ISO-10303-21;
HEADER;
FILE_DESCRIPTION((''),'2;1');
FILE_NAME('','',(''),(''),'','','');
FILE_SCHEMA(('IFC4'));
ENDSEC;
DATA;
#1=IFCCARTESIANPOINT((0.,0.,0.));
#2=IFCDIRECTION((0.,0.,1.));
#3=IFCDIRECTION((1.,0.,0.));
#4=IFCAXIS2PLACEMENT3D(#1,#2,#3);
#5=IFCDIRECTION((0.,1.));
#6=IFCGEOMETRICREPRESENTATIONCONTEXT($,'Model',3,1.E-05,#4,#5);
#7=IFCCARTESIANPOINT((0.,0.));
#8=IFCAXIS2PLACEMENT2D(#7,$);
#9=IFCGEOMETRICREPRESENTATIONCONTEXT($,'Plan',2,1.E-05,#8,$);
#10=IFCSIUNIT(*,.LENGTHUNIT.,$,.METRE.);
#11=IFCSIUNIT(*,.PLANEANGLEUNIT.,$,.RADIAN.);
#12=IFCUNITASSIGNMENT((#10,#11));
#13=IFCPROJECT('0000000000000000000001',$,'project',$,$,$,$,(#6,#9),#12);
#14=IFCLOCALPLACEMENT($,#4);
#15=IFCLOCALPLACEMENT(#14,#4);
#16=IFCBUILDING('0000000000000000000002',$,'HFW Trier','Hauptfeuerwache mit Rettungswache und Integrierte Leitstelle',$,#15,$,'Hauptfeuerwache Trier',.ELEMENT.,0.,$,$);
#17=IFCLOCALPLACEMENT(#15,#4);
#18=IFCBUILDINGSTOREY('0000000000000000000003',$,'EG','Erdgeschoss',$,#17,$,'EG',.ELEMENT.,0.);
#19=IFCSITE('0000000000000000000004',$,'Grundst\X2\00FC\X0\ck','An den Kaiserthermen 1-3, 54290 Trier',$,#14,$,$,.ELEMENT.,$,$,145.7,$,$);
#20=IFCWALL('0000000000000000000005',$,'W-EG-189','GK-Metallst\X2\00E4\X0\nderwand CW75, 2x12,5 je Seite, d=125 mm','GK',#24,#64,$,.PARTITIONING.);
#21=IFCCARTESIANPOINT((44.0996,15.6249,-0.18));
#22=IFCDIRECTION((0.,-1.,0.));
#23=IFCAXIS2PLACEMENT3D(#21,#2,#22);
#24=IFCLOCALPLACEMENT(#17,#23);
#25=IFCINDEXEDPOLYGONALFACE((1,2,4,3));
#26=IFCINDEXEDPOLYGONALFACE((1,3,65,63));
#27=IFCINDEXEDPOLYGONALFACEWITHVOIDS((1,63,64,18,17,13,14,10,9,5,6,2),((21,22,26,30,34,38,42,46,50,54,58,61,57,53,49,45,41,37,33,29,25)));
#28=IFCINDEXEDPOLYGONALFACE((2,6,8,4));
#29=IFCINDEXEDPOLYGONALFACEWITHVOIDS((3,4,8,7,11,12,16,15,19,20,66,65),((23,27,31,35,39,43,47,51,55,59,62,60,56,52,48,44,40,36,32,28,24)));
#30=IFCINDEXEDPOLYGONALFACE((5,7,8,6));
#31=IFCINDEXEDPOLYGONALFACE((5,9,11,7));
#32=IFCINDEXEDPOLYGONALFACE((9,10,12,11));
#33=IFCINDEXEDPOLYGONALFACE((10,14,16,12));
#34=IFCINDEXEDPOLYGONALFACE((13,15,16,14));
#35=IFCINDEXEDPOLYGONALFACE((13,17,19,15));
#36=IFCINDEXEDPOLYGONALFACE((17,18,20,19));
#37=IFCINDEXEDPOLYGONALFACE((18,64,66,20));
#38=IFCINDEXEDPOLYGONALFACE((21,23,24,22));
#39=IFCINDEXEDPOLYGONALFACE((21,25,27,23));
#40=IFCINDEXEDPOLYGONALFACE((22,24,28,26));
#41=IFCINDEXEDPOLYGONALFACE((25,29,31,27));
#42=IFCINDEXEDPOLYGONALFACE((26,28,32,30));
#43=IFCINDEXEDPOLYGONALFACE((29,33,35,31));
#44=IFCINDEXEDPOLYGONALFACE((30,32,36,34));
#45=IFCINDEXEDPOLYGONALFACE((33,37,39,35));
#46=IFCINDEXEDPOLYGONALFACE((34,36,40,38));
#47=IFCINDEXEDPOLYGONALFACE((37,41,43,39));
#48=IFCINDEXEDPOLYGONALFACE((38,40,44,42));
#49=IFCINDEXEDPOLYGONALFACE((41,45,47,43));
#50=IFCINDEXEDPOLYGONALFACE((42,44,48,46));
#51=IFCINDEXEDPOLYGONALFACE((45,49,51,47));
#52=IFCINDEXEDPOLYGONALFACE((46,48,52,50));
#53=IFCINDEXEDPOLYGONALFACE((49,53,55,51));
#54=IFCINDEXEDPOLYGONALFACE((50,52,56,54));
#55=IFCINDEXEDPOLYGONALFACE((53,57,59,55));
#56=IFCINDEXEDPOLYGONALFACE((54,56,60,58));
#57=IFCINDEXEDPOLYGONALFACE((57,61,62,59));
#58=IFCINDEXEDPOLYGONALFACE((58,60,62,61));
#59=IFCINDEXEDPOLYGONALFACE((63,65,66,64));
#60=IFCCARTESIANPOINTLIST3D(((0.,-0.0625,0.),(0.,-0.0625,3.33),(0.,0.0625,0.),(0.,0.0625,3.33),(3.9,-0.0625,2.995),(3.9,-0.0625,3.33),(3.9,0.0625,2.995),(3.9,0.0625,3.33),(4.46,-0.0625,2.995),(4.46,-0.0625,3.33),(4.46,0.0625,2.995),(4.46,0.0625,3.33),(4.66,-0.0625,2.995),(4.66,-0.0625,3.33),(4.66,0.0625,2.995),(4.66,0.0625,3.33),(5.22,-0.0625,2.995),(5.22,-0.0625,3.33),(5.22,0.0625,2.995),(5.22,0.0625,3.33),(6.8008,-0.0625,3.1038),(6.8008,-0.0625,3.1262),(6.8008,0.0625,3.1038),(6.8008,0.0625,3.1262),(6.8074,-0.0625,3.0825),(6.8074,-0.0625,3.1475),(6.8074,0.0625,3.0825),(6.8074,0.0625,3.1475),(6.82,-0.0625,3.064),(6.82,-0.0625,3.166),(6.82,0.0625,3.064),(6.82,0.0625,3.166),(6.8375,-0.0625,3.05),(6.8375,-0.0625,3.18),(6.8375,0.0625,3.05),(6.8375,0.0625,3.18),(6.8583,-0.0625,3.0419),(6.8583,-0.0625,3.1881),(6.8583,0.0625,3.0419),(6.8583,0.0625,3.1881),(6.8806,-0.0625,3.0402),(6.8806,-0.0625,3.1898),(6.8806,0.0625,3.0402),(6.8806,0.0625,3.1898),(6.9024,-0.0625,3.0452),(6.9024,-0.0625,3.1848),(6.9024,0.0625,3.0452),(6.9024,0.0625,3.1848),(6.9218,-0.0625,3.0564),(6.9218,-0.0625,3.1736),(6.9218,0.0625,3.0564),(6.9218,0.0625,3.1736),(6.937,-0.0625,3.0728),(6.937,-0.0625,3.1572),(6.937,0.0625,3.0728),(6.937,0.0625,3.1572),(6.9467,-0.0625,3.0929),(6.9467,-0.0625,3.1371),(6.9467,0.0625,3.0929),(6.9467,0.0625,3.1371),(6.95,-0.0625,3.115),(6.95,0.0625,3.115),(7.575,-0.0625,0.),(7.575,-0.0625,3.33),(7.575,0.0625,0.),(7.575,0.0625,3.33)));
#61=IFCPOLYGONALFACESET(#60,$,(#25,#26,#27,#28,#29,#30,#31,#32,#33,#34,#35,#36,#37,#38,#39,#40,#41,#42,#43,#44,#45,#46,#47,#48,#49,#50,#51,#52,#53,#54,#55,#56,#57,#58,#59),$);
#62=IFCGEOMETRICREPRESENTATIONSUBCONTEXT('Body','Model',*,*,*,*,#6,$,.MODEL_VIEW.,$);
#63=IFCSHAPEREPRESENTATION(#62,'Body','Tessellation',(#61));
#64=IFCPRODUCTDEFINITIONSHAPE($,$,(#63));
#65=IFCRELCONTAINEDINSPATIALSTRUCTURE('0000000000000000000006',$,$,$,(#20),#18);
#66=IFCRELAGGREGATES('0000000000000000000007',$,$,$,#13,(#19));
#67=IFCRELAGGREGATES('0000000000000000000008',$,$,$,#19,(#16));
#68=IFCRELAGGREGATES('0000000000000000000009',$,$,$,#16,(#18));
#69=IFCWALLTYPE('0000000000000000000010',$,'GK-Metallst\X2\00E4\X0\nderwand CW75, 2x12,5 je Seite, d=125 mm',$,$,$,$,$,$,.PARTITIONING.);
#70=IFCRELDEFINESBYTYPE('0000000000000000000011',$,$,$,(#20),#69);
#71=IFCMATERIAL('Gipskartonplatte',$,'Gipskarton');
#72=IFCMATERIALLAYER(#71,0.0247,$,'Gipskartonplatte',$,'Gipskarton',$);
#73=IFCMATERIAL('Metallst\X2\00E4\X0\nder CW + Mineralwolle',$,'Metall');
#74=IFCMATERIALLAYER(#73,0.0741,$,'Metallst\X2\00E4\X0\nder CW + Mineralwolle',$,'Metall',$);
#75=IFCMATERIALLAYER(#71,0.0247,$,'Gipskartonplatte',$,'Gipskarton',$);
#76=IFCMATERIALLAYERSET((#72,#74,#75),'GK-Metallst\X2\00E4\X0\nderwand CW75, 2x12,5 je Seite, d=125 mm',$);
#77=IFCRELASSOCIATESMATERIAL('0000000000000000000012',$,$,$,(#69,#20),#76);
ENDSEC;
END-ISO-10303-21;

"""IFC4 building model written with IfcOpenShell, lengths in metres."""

from ifc_helpers import new_model, si_unit, direction, frame, frame_2d, origin_with_axes, origin_2d, place, context, subcontext, project, spatial, rectangle, circle, extrude, material, layer, layer_set, layer_usage, type_object, element, save


model = new_model("IFC4")

# Units and contexts
model_context = context("Model", 3, precision=1e-05, world=origin_with_axes(), true_north=direction((0.0, 1.0)))
plan_context = context("Plan", 2, precision=1e-05, world=origin_2d())
body_context = subcontext(model_context, "Body", "Model", "MODEL_VIEW")
ifc_project = project(units=[si_unit("LENGTHUNIT", "METRE"), si_unit("PLANEANGLEUNIT", "RADIAN")], contexts=[model_context, plan_context])

# Site, building, storey
site_placement = place(None, origin_with_axes())
site = spatial("IfcSite", under=ifc_project, at=site_placement, Name="Grundstück", Description="An den Kaiserthermen 1-3, 54290 Trier", CompositionType="ELEMENT", RefElevation=145.7)
building_placement = place(site_placement, origin_with_axes())
building = spatial("IfcBuilding", under=site, at=building_placement, Name="HFW Trier", Description="Hauptfeuerwache mit Rettungswache und Integrierte Leitstelle", LongName="Hauptfeuerwache Trier", CompositionType="ELEMENT", ElevationOfRefHeight=0.0)
storey_placement = place(building_placement, origin_with_axes())
storey = spatial("IfcBuildingStorey", under=building, at=storey_placement, Name="EG", Description="Erdgeschoss", LongName="EG", CompositionType="ELEMENT", Elevation=0.0)

# Shared definitions
ifc_material_1 = material(Name="Gipskartonplatte", Category="Gipskarton")
ifc_layer_1 = layer(ifc_material_1, 0.0247, Name="Gipskartonplatte", Category="Gipskarton")
ifc_material_2 = material(Name="Metallständer CW + Mineralwolle", Category="Metall")
ifc_layer_2 = layer(ifc_material_2, 0.0741, Name="Metallständer CW + Mineralwolle", Category="Metall")
ifc_layer_3 = layer(ifc_material_1, 0.0247, Name="Gipskartonplatte", Category="Gipskarton")
ifc_layer_set_1 = layer_set([ifc_layer_1, ifc_layer_2, ifc_layer_3], Name="GK-Metallständerwand CW75, 2x12,5 je Seite, d=125 mm")
wall_type_1 = type_object("IfcWallType", Name="GK-Metallständerwand CW75, 2x12,5 je Seite, d=125 mm", PredefinedType="PARTITIONING", material=ifc_layer_set_1)

# Wall, openings
ifc_layer_usage_1 = layer_usage(ifc_layer_set_1, "AXIS2", "POSITIVE", -0.0625)
wall_1_placement = place(storey_placement, frame((44.0996, 15.6249, -0.18), z_axis=(0.0, 0.0, 1.0), x_axis=(0.0, -1.0, 0.0)))
wall_1 = element("IfcWall", 1, at=wall_1_placement, inside=storey, type_object=wall_type_1, material=ifc_layer_usage_1, Name="W-EG-189", Description="GK-Metallständerwand CW75, 2x12,5 je Seite, d=125 mm", ObjectType="GK", PredefinedType="PARTITIONING", context=body_context, shape_type="SweptSolid", body=[
    extrude(rectangle(XDim=7.575, YDim=0.125, at=frame_2d((3.7875, 0.0))), origin_with_axes(), (0.0, 0.0, 1.0), 3.33),
])
opening_1_placement = place(wall_1_placement, origin_with_axes())
element("IfcOpeningElement", 2, at=opening_1_placement, cuts=wall_1, ObjectType="Wanddurchbruch", PredefinedType="OPENING", context=body_context, shape_type="SweptSolid", body=[
    extrude(circle(Radius=0.075, at=origin_2d()), frame((6.875, -0.1125, 3.115), z_axis=(0.0, 1.0, 0.0), x_axis=(1.0, 0.0, 0.0)), (0.0, 0.0, 1.0), 0.225),
])
opening_2_placement = place(wall_1_placement, origin_with_axes())
element("IfcOpeningElement", 3, at=opening_2_placement, cuts=wall_1, ObjectType="Wanddurchbruch", PredefinedType="OPENING", context=body_context, shape_type="SweptSolid", body=[
    extrude(rectangle(XDim=0.56, YDim=0.225, at=frame_2d((4.18, 0.0))), frame((0.0, 0.0, 2.995), z_axis=(0.0, 0.0, 1.0), x_axis=(1.0, 0.0, 0.0)), (0.0, 0.0, 1.0), 0.335),
])
opening_3_placement = place(wall_1_placement, origin_with_axes())
element("IfcOpeningElement", 4, at=opening_3_placement, cuts=wall_1, ObjectType="Wanddurchbruch", PredefinedType="OPENING", context=body_context, shape_type="SweptSolid", body=[
    extrude(rectangle(XDim=0.56, YDim=0.225, at=frame_2d((4.94, 0.0))), frame((0.0, 0.0, 2.995), z_axis=(0.0, 0.0, 1.0), x_axis=(1.0, 0.0, 0.0)), (0.0, 0.0, 1.0), 0.335),
])

save(model, "model.ifc")
